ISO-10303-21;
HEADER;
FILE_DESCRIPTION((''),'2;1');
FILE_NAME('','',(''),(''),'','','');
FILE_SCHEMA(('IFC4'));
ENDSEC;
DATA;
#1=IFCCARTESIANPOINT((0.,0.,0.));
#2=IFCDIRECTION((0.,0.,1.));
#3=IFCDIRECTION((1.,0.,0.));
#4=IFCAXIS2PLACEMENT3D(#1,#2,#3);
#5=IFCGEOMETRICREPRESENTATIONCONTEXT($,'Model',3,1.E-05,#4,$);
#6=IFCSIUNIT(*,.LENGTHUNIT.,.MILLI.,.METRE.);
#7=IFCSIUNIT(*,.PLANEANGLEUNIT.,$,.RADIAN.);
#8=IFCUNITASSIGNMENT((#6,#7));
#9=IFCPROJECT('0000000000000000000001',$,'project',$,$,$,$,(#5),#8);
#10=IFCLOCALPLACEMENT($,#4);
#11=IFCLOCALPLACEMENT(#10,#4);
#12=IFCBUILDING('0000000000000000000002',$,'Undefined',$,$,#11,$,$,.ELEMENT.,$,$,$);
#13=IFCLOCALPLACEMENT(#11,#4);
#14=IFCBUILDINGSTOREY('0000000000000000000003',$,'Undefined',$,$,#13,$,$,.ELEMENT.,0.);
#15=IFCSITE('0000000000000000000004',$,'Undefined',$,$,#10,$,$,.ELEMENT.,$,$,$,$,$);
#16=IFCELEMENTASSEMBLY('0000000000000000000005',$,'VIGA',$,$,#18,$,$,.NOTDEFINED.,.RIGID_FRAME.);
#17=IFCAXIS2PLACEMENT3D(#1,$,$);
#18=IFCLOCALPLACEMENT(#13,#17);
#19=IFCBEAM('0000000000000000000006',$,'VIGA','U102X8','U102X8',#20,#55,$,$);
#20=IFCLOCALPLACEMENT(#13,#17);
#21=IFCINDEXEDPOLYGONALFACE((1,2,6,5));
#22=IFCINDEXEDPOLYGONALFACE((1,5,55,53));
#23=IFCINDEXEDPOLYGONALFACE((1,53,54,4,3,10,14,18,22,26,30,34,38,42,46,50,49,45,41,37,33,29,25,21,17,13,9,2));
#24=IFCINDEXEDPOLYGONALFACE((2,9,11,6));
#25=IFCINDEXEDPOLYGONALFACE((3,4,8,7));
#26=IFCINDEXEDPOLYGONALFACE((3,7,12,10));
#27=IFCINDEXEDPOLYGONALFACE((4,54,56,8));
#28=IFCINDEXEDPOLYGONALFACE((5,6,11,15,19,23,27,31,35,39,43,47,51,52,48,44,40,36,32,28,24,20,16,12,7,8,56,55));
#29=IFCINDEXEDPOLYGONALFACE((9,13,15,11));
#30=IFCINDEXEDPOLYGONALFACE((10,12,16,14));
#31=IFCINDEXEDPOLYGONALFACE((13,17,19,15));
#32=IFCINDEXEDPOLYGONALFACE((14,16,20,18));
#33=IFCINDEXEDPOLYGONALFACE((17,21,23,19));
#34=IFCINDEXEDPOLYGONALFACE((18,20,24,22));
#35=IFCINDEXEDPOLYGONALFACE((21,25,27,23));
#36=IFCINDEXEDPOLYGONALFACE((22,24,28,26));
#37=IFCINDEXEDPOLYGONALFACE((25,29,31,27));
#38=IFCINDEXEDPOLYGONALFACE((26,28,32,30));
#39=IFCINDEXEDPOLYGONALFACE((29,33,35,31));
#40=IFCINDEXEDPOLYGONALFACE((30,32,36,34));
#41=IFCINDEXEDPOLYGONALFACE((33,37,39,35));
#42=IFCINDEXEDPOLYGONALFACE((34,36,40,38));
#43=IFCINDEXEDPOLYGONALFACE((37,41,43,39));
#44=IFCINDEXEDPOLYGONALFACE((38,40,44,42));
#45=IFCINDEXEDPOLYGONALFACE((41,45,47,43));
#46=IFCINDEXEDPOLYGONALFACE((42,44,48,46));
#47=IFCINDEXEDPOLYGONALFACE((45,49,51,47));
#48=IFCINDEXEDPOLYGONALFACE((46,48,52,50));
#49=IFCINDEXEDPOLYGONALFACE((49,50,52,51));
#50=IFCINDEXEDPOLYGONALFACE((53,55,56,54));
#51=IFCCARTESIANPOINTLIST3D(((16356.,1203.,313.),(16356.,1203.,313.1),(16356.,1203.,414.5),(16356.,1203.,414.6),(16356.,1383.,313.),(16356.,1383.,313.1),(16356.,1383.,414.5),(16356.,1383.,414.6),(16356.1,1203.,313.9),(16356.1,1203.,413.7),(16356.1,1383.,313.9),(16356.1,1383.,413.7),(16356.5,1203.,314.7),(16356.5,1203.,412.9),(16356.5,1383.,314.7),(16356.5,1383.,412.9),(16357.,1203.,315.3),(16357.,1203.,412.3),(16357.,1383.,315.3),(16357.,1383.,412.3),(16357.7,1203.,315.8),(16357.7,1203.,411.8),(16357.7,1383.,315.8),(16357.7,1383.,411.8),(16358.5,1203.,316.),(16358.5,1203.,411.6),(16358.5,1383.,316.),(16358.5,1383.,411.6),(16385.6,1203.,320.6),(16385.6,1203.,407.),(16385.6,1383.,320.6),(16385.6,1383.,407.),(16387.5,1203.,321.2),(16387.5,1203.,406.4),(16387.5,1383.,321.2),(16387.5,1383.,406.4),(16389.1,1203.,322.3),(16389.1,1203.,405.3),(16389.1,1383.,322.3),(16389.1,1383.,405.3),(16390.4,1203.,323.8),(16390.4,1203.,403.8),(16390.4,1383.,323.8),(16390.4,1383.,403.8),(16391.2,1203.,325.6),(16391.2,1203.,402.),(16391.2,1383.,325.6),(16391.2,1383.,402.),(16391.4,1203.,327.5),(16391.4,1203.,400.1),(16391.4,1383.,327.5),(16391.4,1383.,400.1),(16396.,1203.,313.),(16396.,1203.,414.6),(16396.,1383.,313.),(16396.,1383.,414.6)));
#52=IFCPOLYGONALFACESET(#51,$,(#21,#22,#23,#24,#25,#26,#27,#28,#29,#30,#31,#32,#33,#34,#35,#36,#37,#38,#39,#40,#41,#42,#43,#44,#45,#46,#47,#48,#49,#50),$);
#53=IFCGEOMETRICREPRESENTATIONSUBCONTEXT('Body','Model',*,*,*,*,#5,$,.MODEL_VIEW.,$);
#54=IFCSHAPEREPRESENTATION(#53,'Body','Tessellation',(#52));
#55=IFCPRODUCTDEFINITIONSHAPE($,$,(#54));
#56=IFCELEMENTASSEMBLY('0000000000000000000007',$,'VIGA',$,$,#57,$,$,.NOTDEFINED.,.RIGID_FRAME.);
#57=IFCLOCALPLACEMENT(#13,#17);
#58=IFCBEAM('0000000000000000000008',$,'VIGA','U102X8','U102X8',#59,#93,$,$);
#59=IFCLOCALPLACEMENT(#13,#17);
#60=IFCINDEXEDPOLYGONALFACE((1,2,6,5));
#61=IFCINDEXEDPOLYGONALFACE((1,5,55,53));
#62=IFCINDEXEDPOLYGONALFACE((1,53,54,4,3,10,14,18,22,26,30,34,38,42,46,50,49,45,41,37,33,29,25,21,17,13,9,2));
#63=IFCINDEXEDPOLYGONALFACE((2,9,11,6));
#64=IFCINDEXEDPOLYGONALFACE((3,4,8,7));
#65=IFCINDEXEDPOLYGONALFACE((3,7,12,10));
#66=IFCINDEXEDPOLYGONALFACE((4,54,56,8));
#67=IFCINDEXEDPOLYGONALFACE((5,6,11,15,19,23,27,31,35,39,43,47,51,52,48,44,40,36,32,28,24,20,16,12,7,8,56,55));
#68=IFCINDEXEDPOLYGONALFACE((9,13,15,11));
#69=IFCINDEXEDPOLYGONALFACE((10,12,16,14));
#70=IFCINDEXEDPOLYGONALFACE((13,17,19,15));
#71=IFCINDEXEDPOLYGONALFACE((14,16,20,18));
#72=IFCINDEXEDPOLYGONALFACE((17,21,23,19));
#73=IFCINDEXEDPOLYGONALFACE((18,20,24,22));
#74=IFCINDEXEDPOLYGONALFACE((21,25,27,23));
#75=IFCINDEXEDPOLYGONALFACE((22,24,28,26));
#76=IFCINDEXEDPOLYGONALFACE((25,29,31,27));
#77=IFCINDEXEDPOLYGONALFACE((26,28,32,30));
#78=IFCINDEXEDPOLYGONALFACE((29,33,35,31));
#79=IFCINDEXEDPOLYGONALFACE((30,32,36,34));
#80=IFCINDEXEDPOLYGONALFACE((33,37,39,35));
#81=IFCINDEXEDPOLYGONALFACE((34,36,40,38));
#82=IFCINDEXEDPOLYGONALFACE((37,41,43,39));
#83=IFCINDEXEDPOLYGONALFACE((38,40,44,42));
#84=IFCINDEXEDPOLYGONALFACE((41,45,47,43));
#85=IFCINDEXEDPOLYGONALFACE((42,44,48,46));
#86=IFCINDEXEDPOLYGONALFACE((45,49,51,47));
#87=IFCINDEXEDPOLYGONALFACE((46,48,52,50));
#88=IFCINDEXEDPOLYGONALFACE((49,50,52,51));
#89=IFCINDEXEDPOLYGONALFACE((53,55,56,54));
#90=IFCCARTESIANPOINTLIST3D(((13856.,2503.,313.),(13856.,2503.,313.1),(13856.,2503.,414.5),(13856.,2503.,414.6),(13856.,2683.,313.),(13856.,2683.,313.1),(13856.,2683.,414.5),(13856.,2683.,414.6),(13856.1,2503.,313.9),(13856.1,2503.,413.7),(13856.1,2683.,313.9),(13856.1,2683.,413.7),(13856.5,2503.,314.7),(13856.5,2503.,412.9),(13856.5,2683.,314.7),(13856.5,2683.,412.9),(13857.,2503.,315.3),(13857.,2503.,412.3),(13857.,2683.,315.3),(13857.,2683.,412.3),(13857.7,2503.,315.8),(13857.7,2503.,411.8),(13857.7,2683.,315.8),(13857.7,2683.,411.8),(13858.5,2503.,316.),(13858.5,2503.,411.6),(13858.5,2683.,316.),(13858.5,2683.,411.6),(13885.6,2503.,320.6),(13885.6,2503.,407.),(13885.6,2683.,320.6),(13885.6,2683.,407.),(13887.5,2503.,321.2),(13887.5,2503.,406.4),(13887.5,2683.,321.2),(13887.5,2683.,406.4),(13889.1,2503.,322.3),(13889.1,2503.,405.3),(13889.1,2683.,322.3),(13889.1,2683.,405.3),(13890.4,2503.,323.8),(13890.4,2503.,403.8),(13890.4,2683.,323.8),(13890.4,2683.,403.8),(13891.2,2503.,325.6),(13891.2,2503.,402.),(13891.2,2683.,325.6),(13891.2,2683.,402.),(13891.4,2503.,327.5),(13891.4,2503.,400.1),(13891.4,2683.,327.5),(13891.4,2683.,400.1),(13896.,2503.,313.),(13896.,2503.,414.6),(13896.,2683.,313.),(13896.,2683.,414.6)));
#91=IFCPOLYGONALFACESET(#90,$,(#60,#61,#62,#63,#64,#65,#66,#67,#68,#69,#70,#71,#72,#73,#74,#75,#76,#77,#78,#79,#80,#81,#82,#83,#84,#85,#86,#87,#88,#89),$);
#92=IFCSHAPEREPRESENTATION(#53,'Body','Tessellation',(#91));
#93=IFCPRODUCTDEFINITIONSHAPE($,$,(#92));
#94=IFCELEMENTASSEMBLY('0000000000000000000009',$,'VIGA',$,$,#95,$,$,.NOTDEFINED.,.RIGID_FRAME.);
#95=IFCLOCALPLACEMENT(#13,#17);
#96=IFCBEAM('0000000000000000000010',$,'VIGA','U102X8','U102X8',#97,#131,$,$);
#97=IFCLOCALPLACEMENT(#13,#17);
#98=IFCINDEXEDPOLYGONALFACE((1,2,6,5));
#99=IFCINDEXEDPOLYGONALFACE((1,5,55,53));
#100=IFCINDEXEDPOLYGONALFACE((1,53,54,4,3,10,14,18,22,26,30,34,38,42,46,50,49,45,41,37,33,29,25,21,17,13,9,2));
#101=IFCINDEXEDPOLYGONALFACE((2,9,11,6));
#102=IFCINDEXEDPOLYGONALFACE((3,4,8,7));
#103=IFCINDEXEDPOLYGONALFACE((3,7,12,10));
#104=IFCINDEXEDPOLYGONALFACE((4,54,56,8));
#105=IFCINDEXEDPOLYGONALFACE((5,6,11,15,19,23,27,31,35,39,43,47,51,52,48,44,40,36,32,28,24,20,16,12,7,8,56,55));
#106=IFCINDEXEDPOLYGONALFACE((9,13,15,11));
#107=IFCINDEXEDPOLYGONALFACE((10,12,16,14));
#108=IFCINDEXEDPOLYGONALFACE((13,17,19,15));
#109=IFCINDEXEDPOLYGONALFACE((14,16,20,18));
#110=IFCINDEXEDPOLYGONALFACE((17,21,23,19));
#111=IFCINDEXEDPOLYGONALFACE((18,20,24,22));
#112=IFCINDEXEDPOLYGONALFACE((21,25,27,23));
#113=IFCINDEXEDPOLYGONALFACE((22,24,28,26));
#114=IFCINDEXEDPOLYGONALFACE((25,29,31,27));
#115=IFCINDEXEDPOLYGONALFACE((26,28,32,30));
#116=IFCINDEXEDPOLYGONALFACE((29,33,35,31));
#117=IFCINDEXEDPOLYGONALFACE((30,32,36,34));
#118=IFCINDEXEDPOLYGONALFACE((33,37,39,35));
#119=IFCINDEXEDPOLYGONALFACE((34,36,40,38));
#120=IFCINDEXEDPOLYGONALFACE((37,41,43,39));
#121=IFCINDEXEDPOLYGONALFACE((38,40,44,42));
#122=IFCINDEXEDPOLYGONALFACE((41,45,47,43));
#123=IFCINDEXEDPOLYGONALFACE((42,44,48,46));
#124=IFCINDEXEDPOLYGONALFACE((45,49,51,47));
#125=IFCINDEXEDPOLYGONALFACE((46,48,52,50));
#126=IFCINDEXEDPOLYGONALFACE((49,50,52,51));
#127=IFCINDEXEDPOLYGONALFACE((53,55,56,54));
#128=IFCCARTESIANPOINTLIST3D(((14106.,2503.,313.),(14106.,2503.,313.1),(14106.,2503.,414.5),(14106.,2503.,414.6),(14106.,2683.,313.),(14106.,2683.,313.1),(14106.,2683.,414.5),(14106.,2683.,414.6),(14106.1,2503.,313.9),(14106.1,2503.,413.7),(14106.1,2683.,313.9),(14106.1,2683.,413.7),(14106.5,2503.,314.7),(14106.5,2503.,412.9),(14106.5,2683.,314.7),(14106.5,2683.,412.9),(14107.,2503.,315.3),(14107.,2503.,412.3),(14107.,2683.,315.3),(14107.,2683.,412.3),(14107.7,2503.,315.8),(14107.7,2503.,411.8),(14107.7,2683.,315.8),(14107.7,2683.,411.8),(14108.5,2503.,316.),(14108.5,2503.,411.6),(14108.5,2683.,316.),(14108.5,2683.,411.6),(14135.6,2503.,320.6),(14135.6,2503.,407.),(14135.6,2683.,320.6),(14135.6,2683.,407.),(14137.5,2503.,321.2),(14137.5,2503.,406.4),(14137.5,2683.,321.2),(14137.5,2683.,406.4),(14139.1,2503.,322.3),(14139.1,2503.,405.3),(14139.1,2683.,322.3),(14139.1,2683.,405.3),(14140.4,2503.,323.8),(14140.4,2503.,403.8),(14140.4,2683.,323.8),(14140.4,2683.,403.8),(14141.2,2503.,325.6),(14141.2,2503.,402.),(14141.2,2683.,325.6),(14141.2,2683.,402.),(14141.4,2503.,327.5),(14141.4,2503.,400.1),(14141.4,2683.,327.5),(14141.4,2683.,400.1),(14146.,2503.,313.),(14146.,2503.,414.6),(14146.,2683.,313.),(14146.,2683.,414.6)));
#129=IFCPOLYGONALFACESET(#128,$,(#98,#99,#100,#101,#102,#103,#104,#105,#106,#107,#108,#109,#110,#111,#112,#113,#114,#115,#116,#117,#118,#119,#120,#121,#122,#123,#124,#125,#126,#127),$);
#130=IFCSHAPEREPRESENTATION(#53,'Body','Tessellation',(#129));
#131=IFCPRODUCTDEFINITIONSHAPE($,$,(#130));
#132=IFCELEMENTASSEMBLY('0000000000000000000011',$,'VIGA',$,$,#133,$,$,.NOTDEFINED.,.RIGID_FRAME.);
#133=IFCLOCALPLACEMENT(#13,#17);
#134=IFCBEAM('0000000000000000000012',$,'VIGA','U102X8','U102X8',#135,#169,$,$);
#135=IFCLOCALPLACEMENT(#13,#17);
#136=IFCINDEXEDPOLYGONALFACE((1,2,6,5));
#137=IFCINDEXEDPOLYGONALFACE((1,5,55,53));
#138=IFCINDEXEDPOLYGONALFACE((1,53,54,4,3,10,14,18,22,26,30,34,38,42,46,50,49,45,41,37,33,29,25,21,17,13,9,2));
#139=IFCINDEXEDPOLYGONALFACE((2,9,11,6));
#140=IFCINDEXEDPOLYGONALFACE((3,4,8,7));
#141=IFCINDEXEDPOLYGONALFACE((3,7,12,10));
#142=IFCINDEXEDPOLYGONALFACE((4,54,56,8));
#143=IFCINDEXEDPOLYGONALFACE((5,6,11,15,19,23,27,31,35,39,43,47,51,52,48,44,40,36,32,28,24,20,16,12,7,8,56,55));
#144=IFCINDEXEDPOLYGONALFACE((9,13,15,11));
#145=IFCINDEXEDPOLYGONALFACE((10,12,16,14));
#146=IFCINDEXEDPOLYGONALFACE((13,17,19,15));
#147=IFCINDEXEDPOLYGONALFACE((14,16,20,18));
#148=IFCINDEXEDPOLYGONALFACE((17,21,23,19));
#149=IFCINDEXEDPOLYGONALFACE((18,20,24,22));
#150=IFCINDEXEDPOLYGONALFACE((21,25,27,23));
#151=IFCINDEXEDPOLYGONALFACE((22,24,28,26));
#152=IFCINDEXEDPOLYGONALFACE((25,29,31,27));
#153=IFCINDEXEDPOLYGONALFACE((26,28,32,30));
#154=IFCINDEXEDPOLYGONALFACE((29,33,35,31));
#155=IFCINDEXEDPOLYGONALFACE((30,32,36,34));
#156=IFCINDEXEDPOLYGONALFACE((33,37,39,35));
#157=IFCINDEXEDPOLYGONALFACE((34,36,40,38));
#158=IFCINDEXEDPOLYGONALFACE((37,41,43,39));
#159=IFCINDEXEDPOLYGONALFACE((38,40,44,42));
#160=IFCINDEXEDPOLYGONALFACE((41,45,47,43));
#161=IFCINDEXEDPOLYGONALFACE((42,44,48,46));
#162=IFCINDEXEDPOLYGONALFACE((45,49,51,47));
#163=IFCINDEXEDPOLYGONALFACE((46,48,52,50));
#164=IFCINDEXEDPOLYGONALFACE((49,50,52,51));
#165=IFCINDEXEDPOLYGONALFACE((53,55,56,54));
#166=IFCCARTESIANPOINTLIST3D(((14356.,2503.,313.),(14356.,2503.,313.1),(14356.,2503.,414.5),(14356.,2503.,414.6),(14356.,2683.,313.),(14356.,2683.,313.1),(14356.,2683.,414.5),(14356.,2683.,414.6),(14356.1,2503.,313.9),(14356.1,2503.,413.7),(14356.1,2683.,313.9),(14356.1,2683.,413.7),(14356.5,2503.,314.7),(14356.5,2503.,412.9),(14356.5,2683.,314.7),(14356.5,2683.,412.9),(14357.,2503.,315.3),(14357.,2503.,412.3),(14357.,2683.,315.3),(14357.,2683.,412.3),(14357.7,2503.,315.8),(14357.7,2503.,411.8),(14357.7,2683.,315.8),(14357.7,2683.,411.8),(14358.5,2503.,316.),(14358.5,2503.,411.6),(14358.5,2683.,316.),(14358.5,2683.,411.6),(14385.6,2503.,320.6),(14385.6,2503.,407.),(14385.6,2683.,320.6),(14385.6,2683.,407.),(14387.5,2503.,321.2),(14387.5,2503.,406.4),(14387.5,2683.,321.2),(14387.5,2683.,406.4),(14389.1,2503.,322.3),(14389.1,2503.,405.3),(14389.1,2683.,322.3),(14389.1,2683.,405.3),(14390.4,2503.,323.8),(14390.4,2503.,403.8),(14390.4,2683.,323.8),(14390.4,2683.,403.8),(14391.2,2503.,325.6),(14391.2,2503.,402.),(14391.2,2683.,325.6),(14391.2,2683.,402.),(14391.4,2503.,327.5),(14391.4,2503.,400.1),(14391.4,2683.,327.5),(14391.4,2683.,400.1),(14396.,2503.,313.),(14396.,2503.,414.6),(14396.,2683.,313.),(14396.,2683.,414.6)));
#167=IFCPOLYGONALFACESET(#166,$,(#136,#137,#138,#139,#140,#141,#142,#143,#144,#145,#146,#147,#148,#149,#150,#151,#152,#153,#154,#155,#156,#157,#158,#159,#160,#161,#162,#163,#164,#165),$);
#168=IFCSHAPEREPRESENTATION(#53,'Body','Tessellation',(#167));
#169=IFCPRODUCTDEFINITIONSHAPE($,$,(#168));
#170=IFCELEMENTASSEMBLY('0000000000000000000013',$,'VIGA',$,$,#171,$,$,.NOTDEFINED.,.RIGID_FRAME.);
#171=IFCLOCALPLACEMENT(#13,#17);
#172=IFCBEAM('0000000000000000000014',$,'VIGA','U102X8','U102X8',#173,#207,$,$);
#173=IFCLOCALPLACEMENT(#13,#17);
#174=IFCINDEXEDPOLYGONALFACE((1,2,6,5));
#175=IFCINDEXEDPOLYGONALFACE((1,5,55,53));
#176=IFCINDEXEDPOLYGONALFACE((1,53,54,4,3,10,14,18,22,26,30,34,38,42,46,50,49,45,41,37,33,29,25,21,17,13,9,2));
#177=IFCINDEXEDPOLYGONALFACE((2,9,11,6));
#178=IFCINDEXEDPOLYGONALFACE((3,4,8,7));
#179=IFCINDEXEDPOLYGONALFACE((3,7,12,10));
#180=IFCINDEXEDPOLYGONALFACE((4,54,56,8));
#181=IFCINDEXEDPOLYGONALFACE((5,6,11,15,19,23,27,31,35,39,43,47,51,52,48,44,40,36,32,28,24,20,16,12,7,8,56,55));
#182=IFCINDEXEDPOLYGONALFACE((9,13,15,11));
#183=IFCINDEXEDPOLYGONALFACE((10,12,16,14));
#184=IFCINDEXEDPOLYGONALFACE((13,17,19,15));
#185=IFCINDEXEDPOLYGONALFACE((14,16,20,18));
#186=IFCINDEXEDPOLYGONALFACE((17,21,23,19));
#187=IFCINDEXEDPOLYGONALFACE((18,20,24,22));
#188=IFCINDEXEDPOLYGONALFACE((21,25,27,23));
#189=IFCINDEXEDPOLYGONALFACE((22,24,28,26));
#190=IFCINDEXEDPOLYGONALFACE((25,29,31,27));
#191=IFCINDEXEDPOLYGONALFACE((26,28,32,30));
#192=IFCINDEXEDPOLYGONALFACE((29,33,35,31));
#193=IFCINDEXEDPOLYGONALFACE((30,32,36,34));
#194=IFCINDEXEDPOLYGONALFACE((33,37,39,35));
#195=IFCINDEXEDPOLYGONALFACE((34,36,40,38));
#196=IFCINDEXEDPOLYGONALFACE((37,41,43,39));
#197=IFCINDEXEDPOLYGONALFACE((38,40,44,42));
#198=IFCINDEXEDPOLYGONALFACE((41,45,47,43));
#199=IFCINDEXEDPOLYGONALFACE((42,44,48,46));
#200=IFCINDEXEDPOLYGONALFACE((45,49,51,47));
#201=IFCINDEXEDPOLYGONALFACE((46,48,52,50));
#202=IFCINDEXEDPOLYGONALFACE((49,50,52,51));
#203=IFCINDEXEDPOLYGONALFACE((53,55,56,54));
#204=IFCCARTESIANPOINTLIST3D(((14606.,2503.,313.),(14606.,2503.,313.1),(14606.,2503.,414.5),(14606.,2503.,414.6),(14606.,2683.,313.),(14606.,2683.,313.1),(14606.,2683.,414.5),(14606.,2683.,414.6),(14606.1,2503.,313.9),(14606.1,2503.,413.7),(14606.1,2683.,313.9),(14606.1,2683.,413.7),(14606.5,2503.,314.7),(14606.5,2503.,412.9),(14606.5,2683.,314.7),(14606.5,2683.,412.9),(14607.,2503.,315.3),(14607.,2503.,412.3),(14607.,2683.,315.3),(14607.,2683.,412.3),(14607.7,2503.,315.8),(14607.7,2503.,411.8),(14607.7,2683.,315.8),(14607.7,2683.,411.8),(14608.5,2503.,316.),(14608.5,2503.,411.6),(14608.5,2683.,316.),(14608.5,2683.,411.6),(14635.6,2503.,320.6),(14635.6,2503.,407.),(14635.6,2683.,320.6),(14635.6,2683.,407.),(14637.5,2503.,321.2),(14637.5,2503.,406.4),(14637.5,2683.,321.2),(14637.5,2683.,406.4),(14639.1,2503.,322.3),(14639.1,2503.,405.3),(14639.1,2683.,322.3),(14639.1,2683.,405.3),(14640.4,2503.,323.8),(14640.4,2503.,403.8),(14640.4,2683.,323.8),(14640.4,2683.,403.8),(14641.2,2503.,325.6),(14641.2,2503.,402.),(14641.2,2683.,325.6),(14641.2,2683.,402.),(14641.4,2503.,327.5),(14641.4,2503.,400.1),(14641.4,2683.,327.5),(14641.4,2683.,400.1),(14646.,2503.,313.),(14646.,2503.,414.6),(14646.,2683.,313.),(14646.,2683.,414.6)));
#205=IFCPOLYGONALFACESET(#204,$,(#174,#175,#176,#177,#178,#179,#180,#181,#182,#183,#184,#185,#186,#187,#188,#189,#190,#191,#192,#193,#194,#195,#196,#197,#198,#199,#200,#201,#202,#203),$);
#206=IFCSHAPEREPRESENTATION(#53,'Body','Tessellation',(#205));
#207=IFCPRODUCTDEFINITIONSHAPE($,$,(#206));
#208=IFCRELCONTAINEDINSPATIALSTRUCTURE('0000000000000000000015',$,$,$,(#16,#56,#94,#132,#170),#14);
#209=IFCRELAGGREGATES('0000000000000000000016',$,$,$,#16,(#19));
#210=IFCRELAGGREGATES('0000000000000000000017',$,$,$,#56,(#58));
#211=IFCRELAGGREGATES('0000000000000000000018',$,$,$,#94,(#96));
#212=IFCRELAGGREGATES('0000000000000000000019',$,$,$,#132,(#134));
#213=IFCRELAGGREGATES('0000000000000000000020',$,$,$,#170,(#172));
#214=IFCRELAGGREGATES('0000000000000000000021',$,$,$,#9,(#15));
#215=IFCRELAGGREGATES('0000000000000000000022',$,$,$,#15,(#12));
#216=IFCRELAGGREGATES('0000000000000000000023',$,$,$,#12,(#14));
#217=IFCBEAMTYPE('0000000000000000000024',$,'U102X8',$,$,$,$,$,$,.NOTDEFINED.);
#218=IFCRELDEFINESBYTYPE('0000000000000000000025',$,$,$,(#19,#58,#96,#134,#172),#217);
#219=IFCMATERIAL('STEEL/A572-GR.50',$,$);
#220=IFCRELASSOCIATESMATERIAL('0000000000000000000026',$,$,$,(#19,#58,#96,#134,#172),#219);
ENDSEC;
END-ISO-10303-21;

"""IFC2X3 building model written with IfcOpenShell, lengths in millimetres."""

from ifc_helpers import new_model, si_unit, frame, origin_with_axes, origin_2d_with_axis, place, context, subcontext, project, spatial, u_section, extrude, material, type_object, element, aggregate, save


model = new_model("IFC2X3")

# Units and contexts
model_context = context("Model", 3, precision=1e-05, world=origin_with_axes())
body_context = subcontext(model_context, "Body", "Model", "MODEL_VIEW")
ifc_project = project(units=[si_unit("LENGTHUNIT", "METRE", prefix="MILLI"), si_unit("PLANEANGLEUNIT", "RADIAN")], contexts=[model_context])

# Site, building, storey
site_placement = place(None, origin_with_axes())
site = spatial("IfcSite", under=ifc_project, at=site_placement, Name="Undefined", CompositionType="ELEMENT")
building_placement = place(site_placement, origin_with_axes())
building = spatial("IfcBuilding", under=site, at=building_placement, Name="Undefined", CompositionType="ELEMENT")
storey_placement = place(building_placement, origin_with_axes())
storey = spatial("IfcBuildingStorey", under=building, at=storey_placement, Name="Undefined", CompositionType="ELEMENT", Elevation=0.0)

# Element assemblies, beams
ifc_material = material(Name="STEEL/A572-GR.50")
beam_type = type_object("IfcBeamType", Name="U102X8", PredefinedType="NOTDEFINED")
assembly_1_placement = place(storey_placement, origin_with_axes())
assembly_1 = element("IfcElementAssembly", 1, at=assembly_1_placement, inside=storey, Name="VIGA", AssemblyPlace="NOTDEFINED", PredefinedType="RIGID_FRAME")
beam_1_placement = place(assembly_1_placement, frame((16376.0, 1383.0, 363.8), z_axis=(0.0, 0.0, 1.0), x_axis=(0.0, -1.0, 0.0)))
beam_1 = element("IfcBeam", 2, at=beam_1_placement, type_object=beam_type, material=ifc_material, Name="VIGA", Description="U102X8", ObjectType="U102X8", context=body_context, shape_type="SweptSolid", body=[
    extrude(u_section(Depth=101.6, FlangeWidth=40.0, WebThickness=4.6, FlangeThickness=6.0, FilletRadius=7.0, EdgeRadius=3.0, FlangeSlope=0.16839, at=origin_2d_with_axis()), frame((180.0, 0.0, 0.0), z_axis=(-1.0, 0.0, 0.0), x_axis=(0.0, -1.0, 0.0)), (0.0, 0.0, 1.0), 180.0),
])
aggregate(assembly_1, [beam_1])
assembly_2_placement = place(storey_placement, origin_with_axes())
assembly_2 = element("IfcElementAssembly", 3, at=assembly_2_placement, inside=storey, Name="VIGA", AssemblyPlace="NOTDEFINED", PredefinedType="RIGID_FRAME")
beam_2_placement = place(assembly_2_placement, frame((13876.0, 2683.0, 363.8), z_axis=(0.0, 0.0, 1.0), x_axis=(0.0, -1.0, 0.0)))
beam_2 = element("IfcBeam", 4, at=beam_2_placement, type_object=beam_type, material=ifc_material, Name="VIGA", Description="U102X8", ObjectType="U102X8", context=body_context, shape_type="SweptSolid", body=[
    extrude(u_section(Depth=101.6, FlangeWidth=40.0, WebThickness=4.6, FlangeThickness=6.0, FilletRadius=7.0, EdgeRadius=3.0, FlangeSlope=0.16839, at=origin_2d_with_axis()), frame((180.0, 0.0, 0.0), z_axis=(-1.0, 0.0, 0.0), x_axis=(0.0, -1.0, 0.0)), (0.0, 0.0, 1.0), 180.0),
])
aggregate(assembly_2, [beam_2])
assembly_3_placement = place(storey_placement, origin_with_axes())
assembly_3 = element("IfcElementAssembly", 5, at=assembly_3_placement, inside=storey, Name="VIGA", AssemblyPlace="NOTDEFINED", PredefinedType="RIGID_FRAME")
beam_3_placement = place(assembly_3_placement, frame((14126.0, 2683.0, 363.8), z_axis=(0.0, 0.0, 1.0), x_axis=(0.0, -1.0, 0.0)))
beam_3 = element("IfcBeam", 6, at=beam_3_placement, type_object=beam_type, material=ifc_material, Name="VIGA", Description="U102X8", ObjectType="U102X8", context=body_context, shape_type="SweptSolid", body=[
    extrude(u_section(Depth=101.6, FlangeWidth=40.0, WebThickness=4.6, FlangeThickness=6.0, FilletRadius=7.0, EdgeRadius=3.0, FlangeSlope=0.16839, at=origin_2d_with_axis()), frame((180.0, 0.0, 0.0), z_axis=(-1.0, 0.0, 0.0), x_axis=(0.0, -1.0, 0.0)), (0.0, 0.0, 1.0), 180.0),
])
aggregate(assembly_3, [beam_3])
assembly_4_placement = place(storey_placement, origin_with_axes())
assembly_4 = element("IfcElementAssembly", 7, at=assembly_4_placement, inside=storey, Name="VIGA", AssemblyPlace="NOTDEFINED", PredefinedType="RIGID_FRAME")
beam_4_placement = place(assembly_4_placement, frame((14376.0, 2683.0, 363.8), z_axis=(0.0, 0.0, 1.0), x_axis=(0.0, -1.0, 0.0)))
beam_4 = element("IfcBeam", 8, at=beam_4_placement, type_object=beam_type, material=ifc_material, Name="VIGA", Description="U102X8", ObjectType="U102X8", context=body_context, shape_type="SweptSolid", body=[
    extrude(u_section(Depth=101.6, FlangeWidth=40.0, WebThickness=4.6, FlangeThickness=6.0, FilletRadius=7.0, EdgeRadius=3.0, FlangeSlope=0.16839, at=origin_2d_with_axis()), frame((180.0, 0.0, 0.0), z_axis=(-1.0, 0.0, 0.0), x_axis=(0.0, -1.0, 0.0)), (0.0, 0.0, 1.0), 180.0),
])
aggregate(assembly_4, [beam_4])
assembly_5_placement = place(storey_placement, origin_with_axes())
assembly_5 = element("IfcElementAssembly", 9, at=assembly_5_placement, inside=storey, Name="VIGA", AssemblyPlace="NOTDEFINED", PredefinedType="RIGID_FRAME")
beam_5_placement = place(assembly_5_placement, frame((14626.0, 2683.0, 363.8), z_axis=(0.0, 0.0, 1.0), x_axis=(0.0, -1.0, 0.0)))
beam_5 = element("IfcBeam", 10, at=beam_5_placement, type_object=beam_type, material=ifc_material, Name="VIGA", Description="U102X8", ObjectType="U102X8", context=body_context, shape_type="SweptSolid", body=[
    extrude(u_section(Depth=101.6, FlangeWidth=40.0, WebThickness=4.6, FlangeThickness=6.0, FilletRadius=7.0, EdgeRadius=3.0, FlangeSlope=0.16839, at=origin_2d_with_axis()), frame((180.0, 0.0, 0.0), z_axis=(-1.0, 0.0, 0.0), x_axis=(0.0, -1.0, 0.0)), (0.0, 0.0, 1.0), 180.0),
])
aggregate(assembly_5, [beam_5])

save(model, "model.ifc")
